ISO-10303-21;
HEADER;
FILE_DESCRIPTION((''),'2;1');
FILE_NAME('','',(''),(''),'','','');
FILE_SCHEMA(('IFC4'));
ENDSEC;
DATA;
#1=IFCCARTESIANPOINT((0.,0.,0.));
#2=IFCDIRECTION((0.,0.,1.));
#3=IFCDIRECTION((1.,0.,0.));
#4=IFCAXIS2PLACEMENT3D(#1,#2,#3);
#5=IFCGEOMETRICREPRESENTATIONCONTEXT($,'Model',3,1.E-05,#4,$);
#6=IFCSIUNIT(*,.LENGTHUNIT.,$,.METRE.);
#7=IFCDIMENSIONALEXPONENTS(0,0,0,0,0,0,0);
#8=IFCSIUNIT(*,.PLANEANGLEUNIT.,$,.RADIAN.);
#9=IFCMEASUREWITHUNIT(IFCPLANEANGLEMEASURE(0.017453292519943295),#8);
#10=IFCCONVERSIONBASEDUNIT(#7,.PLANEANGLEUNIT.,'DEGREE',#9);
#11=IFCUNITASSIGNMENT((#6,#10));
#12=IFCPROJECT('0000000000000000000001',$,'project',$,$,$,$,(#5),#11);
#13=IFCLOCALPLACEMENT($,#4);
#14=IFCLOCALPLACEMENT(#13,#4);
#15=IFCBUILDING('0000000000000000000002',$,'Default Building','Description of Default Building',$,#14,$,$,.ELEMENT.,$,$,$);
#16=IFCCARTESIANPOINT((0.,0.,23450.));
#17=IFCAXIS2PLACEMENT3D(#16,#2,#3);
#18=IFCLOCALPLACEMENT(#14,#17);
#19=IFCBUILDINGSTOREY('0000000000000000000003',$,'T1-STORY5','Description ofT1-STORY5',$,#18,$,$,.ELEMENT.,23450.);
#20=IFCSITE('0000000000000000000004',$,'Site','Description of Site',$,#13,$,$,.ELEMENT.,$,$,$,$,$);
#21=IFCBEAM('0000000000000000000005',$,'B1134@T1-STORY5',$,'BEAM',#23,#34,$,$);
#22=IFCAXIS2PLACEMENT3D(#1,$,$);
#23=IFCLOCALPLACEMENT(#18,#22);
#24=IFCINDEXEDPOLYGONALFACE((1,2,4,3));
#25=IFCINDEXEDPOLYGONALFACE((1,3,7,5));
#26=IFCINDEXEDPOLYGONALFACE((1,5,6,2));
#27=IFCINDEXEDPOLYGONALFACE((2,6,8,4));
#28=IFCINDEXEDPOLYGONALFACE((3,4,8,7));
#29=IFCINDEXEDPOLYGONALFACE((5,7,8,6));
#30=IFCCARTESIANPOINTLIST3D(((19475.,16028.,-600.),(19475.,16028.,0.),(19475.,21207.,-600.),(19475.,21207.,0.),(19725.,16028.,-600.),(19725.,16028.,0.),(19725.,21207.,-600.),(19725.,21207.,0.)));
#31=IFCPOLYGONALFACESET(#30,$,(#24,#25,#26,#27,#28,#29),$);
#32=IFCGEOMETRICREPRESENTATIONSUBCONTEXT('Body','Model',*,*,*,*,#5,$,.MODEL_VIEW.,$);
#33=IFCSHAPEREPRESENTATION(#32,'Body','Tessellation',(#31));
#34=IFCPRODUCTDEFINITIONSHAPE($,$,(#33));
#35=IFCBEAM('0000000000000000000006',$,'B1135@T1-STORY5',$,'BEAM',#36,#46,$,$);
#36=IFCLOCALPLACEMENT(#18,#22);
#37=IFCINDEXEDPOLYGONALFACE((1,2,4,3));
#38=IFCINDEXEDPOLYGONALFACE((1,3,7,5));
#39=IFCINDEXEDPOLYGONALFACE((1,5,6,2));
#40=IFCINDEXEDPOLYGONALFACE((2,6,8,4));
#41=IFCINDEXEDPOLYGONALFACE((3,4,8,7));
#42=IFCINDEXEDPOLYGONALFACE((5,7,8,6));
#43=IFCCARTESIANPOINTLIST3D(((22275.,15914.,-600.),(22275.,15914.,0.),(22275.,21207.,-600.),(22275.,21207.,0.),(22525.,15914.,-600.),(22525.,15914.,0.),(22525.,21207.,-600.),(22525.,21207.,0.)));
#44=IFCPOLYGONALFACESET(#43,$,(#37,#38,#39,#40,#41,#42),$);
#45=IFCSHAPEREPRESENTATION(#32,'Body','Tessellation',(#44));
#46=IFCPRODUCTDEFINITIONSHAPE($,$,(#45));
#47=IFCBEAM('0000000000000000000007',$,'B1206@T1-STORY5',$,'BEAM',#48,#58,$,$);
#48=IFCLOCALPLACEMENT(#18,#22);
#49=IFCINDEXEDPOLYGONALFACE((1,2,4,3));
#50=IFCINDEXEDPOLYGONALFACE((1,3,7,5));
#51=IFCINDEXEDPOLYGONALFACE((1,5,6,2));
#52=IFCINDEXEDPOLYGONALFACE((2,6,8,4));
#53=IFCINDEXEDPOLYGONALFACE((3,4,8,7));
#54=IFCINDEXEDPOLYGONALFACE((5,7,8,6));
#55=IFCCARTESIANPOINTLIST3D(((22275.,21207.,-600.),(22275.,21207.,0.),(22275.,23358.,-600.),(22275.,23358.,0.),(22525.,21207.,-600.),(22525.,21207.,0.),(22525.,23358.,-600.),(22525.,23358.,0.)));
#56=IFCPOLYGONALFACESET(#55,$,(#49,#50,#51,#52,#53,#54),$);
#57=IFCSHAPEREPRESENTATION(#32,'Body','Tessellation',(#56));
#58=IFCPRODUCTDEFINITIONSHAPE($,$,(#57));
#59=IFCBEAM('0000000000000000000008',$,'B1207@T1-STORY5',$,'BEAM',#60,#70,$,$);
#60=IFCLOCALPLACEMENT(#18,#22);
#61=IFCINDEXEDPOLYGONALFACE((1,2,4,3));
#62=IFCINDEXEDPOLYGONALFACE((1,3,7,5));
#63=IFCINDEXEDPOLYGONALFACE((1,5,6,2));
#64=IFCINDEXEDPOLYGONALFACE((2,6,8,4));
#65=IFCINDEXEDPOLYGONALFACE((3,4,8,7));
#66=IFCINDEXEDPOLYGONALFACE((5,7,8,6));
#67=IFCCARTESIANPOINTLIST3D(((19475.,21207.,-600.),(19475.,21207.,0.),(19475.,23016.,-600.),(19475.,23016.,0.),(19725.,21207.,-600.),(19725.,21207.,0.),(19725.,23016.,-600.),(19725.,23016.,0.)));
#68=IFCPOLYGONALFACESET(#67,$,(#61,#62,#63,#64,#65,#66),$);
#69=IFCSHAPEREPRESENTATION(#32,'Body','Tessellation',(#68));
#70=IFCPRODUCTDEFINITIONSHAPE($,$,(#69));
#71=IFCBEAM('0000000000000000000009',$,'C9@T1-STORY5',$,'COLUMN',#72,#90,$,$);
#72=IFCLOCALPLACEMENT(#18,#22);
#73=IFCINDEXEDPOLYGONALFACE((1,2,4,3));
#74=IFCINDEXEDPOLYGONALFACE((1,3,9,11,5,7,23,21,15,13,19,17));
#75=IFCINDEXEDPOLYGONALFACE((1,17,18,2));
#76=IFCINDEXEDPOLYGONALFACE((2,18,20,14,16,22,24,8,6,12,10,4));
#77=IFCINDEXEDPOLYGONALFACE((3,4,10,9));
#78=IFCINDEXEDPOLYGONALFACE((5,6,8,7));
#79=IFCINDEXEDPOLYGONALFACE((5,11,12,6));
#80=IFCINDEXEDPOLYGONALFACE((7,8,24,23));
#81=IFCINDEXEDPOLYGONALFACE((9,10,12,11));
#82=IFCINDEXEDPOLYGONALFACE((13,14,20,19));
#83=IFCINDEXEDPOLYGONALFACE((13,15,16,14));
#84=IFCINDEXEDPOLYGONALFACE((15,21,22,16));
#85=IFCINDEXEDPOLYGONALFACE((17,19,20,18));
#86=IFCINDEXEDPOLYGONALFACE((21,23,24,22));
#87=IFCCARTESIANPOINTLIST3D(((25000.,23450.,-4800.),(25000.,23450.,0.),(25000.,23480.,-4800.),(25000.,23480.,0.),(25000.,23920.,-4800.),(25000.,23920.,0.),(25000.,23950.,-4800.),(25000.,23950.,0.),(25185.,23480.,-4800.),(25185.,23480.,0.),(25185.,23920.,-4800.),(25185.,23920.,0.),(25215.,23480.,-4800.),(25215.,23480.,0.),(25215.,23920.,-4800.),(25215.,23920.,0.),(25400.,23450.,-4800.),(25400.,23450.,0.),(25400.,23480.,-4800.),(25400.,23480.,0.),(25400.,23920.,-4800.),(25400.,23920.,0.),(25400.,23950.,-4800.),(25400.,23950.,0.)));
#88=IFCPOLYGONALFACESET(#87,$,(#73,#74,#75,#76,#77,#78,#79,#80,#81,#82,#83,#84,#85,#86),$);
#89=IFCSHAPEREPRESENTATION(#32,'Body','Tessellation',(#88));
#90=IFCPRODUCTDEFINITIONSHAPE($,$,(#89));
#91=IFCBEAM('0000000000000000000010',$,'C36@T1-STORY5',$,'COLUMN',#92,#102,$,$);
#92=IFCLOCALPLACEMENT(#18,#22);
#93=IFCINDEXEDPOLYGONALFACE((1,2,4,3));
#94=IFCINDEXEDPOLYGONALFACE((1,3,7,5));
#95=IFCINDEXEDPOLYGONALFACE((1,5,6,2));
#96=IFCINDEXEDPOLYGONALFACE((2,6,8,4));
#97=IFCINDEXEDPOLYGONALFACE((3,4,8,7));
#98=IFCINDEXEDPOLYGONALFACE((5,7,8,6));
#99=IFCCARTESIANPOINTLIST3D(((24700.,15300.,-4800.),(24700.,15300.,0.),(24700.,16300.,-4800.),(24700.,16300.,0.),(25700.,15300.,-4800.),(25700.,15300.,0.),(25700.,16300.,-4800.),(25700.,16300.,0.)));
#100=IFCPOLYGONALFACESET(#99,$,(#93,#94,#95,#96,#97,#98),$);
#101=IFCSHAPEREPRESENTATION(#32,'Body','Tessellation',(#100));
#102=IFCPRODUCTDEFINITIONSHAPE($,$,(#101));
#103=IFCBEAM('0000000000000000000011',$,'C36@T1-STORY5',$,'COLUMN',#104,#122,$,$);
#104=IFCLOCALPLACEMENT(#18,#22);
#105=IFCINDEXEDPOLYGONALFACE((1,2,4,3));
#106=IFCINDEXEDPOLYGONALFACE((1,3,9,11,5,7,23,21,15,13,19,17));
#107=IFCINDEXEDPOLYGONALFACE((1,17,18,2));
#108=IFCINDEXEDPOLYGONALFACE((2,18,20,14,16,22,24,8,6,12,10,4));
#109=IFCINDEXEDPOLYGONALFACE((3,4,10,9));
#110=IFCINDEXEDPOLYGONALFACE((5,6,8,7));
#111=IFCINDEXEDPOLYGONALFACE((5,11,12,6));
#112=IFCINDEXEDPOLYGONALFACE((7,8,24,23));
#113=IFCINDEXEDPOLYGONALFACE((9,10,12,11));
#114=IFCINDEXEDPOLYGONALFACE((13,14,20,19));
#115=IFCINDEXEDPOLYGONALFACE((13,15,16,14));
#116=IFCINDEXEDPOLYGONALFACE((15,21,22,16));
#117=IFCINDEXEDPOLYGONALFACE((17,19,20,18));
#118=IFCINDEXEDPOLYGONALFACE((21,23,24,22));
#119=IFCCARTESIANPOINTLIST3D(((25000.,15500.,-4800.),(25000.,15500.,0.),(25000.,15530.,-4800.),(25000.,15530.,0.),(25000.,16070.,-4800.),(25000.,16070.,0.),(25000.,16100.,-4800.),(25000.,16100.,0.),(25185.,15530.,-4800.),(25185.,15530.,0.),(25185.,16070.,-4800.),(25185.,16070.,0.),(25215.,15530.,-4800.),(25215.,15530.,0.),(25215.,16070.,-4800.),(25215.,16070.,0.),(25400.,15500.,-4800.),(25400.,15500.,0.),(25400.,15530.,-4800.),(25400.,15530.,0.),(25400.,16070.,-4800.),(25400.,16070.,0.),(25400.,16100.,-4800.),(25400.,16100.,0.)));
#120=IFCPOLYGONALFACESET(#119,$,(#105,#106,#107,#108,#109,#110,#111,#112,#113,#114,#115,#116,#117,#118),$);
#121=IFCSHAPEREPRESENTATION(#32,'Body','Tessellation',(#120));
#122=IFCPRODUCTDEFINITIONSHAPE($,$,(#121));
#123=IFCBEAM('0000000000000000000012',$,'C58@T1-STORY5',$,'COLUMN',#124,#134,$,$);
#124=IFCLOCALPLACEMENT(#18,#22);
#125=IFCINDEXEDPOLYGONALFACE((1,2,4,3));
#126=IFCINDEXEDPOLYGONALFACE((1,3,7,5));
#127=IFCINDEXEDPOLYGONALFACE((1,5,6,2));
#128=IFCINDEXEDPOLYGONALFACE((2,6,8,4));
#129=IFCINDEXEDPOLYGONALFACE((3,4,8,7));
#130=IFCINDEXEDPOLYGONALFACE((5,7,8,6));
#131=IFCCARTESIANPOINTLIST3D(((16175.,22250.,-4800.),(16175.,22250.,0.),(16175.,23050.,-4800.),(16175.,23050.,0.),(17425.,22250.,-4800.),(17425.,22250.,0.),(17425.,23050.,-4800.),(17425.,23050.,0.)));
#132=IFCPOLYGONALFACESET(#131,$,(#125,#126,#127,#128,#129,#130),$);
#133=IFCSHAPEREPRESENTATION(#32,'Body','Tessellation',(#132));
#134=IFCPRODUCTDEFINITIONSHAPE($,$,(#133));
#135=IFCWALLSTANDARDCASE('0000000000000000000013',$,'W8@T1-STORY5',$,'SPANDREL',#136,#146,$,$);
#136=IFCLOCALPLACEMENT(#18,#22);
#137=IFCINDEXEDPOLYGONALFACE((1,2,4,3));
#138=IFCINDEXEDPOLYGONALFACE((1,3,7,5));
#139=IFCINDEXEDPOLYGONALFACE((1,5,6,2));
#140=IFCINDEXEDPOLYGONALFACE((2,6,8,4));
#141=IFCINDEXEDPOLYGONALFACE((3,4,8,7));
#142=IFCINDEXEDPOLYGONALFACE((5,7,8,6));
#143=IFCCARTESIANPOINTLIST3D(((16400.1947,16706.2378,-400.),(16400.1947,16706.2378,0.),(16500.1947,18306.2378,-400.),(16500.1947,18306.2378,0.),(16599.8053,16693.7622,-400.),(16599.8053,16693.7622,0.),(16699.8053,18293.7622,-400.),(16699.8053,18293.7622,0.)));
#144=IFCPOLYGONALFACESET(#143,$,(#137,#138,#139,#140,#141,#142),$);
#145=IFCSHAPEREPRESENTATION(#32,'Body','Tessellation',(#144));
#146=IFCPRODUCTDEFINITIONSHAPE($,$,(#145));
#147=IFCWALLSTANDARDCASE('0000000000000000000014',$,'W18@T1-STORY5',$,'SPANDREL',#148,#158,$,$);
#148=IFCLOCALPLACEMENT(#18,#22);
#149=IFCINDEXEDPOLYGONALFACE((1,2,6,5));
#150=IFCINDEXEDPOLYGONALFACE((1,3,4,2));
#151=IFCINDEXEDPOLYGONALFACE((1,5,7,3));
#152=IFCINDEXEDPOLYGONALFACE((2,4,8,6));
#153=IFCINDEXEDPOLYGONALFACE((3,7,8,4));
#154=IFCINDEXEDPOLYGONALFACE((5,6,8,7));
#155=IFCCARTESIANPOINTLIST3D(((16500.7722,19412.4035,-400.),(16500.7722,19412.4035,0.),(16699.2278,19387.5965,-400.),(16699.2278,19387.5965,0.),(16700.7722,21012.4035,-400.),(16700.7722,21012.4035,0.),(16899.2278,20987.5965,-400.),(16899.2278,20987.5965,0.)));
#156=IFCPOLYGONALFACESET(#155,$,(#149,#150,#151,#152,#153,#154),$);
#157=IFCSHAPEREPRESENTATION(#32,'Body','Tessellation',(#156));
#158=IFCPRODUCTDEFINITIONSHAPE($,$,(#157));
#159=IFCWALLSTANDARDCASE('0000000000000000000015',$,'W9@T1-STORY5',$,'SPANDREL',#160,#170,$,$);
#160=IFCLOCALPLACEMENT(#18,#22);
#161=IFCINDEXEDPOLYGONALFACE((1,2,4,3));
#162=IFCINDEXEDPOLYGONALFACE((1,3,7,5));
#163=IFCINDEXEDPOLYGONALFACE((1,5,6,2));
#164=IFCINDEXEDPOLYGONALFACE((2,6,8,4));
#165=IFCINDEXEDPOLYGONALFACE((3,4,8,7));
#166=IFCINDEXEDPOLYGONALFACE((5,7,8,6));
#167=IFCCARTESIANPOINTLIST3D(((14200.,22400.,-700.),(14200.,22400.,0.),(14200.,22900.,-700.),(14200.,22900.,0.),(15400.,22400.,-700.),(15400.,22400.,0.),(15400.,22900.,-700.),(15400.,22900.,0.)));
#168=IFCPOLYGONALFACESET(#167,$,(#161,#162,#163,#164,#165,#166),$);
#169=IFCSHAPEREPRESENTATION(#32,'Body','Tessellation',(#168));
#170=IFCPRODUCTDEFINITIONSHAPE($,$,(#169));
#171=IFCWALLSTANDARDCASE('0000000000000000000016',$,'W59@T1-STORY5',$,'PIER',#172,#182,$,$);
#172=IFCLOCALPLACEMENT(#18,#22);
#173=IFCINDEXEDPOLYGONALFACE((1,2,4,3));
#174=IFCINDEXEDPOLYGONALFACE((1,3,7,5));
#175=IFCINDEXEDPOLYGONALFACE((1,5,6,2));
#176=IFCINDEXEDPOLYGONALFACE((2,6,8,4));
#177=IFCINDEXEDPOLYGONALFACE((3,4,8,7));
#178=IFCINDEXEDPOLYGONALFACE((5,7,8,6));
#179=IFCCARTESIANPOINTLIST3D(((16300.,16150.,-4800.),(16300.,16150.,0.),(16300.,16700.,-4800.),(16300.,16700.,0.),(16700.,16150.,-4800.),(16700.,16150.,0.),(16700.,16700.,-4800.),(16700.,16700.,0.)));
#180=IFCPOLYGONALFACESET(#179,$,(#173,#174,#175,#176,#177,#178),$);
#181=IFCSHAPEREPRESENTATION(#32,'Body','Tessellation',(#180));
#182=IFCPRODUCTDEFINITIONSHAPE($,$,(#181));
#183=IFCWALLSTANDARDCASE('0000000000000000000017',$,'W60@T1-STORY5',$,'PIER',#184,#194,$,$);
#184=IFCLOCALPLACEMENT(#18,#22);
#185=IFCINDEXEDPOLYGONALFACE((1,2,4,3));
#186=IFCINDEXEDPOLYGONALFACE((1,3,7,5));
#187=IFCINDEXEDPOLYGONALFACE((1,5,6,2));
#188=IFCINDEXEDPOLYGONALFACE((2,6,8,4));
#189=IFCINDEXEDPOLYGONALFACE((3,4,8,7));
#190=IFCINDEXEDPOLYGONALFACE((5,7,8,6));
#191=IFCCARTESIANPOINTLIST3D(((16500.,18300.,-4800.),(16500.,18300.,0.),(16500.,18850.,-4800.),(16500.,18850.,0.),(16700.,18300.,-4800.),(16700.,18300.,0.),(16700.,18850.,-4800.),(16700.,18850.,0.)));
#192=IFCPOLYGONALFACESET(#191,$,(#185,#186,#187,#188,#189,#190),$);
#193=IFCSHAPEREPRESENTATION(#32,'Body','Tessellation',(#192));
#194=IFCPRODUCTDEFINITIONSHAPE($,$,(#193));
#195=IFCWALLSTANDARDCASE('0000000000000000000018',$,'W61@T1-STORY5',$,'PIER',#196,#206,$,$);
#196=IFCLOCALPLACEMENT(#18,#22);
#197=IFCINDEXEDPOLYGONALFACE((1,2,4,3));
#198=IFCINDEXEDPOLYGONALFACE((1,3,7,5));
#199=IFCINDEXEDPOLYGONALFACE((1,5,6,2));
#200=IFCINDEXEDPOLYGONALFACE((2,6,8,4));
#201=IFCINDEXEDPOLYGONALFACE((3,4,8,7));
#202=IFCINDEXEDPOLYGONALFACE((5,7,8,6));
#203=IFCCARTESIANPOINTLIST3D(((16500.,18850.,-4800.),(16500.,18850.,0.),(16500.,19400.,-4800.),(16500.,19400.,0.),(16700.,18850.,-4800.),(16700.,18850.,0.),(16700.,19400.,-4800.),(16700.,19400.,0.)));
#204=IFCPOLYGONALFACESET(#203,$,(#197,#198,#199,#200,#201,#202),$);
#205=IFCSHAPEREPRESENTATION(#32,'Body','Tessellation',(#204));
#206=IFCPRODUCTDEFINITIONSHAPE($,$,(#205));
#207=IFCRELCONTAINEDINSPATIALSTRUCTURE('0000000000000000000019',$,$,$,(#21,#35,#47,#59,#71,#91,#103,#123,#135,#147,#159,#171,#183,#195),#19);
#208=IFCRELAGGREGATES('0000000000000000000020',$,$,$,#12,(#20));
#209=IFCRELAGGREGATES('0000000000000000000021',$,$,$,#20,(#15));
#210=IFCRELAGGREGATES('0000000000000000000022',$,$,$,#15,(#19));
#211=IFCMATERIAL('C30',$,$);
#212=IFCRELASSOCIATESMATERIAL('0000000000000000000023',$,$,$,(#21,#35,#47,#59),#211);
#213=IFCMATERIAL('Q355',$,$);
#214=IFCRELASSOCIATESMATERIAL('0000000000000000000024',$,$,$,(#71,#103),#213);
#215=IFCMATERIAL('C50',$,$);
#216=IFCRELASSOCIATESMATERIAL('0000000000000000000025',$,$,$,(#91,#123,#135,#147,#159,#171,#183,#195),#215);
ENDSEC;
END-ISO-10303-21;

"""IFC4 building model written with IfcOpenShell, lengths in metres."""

from ifc_helpers import new_model, entity, si_unit, converted_unit, frame, origin_with_axes, place, context, subcontext, project, spatial, indexed_curve, rectangle, i_section, outline, extrude, material, element, save


model = new_model("IFC4")

# Units and contexts
model_context = context("Model", 3, precision=1e-05, world=origin_with_axes())
body_context = subcontext(model_context, "Body", "Model", "MODEL_VIEW")
ifc_project = project(units=[si_unit("LENGTHUNIT", "METRE"), converted_unit("PLANEANGLEUNIT", "DEGREE", entity("IfcPlaneAngleMeasure", 0.017453292519943295), si_unit("PLANEANGLEUNIT", "RADIAN"), dimensions=[0, 0, 0, 0, 0, 0, 0])], contexts=[model_context])

# Site, building, storey
site_placement = place(None, origin_with_axes())
site = spatial("IfcSite", under=ifc_project, at=site_placement, Name="Site", Description="Description of Site", CompositionType="ELEMENT")
building_placement = place(site_placement, origin_with_axes())
building = spatial("IfcBuilding", under=site, at=building_placement, Name="Default Building", Description="Description of Default Building", CompositionType="ELEMENT")
storey_placement = place(building_placement, frame((0.0, 0.0, 23450.0), z_axis=(0.0, 0.0, 1.0), x_axis=(1.0, 0.0, 0.0)))
storey = spatial("IfcBuildingStorey", under=building, at=storey_placement, Name="T1-STORY5", Description="Description ofT1-STORY5", CompositionType="ELEMENT", Elevation=23450.0)

# Beams
ifc_material_1 = material(Name="C30")
beam_1_placement = place(storey_placement, frame((19600.0, 16028.0, -300.0), z_axis=(0.0, 1.0, 0.0), x_axis=(-1.0, 0.0, 0.0)))
element("IfcBeam", 1, at=beam_1_placement, inside=storey, material=ifc_material_1, Name="B1134@T1-STORY5", ObjectType="BEAM", context=body_context, shape_type="SweptSolid", body=[
    extrude(rectangle(XDim=250.0, YDim=600.0), origin_with_axes(), (0.0, 0.0, 1.0), 5179.0),
])
beam_2_placement = place(storey_placement, frame((22400.0, 15914.0, -300.0), z_axis=(0.0, 1.0, 0.0), x_axis=(-1.0, 0.0, 0.0)))
element("IfcBeam", 2, at=beam_2_placement, inside=storey, material=ifc_material_1, Name="B1135@T1-STORY5", ObjectType="BEAM", context=body_context, shape_type="SweptSolid", body=[
    extrude(rectangle(XDim=250.0, YDim=600.0), origin_with_axes(), (0.0, 0.0, 1.0), 5293.0),
])
beam_3_placement = place(storey_placement, frame((22400.0, 21207.0, -300.0), z_axis=(0.0, 1.0, 0.0), x_axis=(-1.0, 0.0, 0.0)))
element("IfcBeam", 3, at=beam_3_placement, inside=storey, material=ifc_material_1, Name="B1206@T1-STORY5", ObjectType="BEAM", context=body_context, shape_type="SweptSolid", body=[
    extrude(rectangle(XDim=250.0, YDim=600.0), origin_with_axes(), (0.0, 0.0, 1.0), 2151.0),
])
beam_4_placement = place(storey_placement, frame((19600.0, 21207.0, -300.0), z_axis=(0.0, 1.0, 0.0), x_axis=(-1.0, 0.0, 0.0)))
element("IfcBeam", 4, at=beam_4_placement, inside=storey, material=ifc_material_1, Name="B1207@T1-STORY5", ObjectType="BEAM", context=body_context, shape_type="SweptSolid", body=[
    extrude(rectangle(XDim=250.0, YDim=600.0), origin_with_axes(), (0.0, 0.0, 1.0), 1809.0),
])
ifc_material_2 = material(Name="C50")
ifc_material_3 = material(Name="Q355")
beam_5_placement = place(storey_placement, frame((25200.0, 23700.0, -4800.0), z_axis=(0.0, 0.0, 1.0), x_axis=(-1.0, 0.0, 0.0)))
element("IfcBeam", 5, at=beam_5_placement, inside=storey, material=ifc_material_3, Name="C9@T1-STORY5", ObjectType="COLUMN", context=body_context, shape_type="SweptSolid", body=[
    extrude(i_section(OverallWidth=400.0, OverallDepth=500.0, WebThickness=30.0, FlangeThickness=30.0, FilletRadius=0.0), origin_with_axes(), (0.0, 0.0, 1.0), 4800.0),
])
beam_6_placement = place(storey_placement, frame((25200.0, 15800.0, -4800.0), z_axis=(0.0, 0.0, 1.0), x_axis=(-1.0, 0.0, 0.0)))
element("IfcBeam", 6, at=beam_6_placement, inside=storey, material=ifc_material_2, Name="C36@T1-STORY5", ObjectType="COLUMN", context=body_context, shape_type="SweptSolid", body=[
    extrude(rectangle(XDim=1000.0, YDim=1000.0), origin_with_axes(), (0.0, 0.0, 1.0), 4800.0),
])
beam_7_placement = place(storey_placement, frame((25200.0, 15800.0, -4800.0), z_axis=(0.0, 0.0, 1.0), x_axis=(-1.0, 0.0, 0.0)))
element("IfcBeam", 7, at=beam_7_placement, inside=storey, material=ifc_material_3, Name="C36@T1-STORY5", ObjectType="COLUMN", context=body_context, shape_type="SweptSolid", body=[
    extrude(i_section(OverallWidth=400.0, OverallDepth=600.0, WebThickness=30.0, FlangeThickness=30.0, FilletRadius=0.0), origin_with_axes(), (0.0, 0.0, 1.0), 4800.0),
])
beam_8_placement = place(storey_placement, frame((16800.0, 22650.0, -4800.0), z_axis=(0.0, 0.0, 1.0), x_axis=(0.0, -1.0, 0.0)))
element("IfcBeam", 8, at=beam_8_placement, inside=storey, material=ifc_material_2, Name="C58@T1-STORY5", ObjectType="COLUMN", context=body_context, shape_type="SweptSolid", body=[
    extrude(rectangle(XDim=800.0, YDim=1250.0), origin_with_axes(), (0.0, 0.0, 1.0), 4800.0),
])

# Walls
wall_1_placement = place(storey_placement, frame((16500.0, 16700.0, -400.0), z_axis=(0.0, 0.0, 1.0), x_axis=(0.062378, 0.998053, 0.0)))
element("IfcWallStandardCase", 9, at=wall_1_placement, inside=storey, material=ifc_material_2, Name="W8@T1-STORY5", ObjectType="SPANDREL", context=body_context, shape_type="SweptSolid", body=[
    extrude(outline(indexed_curve([(0.0, -100.0), (0.0, 100.0), (1603.122, 100.0), (1603.122, -100.0), (0.0, -100.0)], self_intersect=False)), origin_with_axes(), (0.0, 0.0, 1.0), 400.0),
])
wall_2_placement = place(storey_placement, frame((16600.0, 19400.0, -400.0), z_axis=(0.0, 0.0, 1.0), x_axis=(0.124035, 0.992278, 0.0)))
element("IfcWallStandardCase", 10, at=wall_2_placement, inside=storey, material=ifc_material_2, Name="W18@T1-STORY5", ObjectType="SPANDREL", context=body_context, shape_type="SweptSolid", body=[
    extrude(outline(indexed_curve([(0.0, -100.0), (0.0, 100.0), (1612.4515, 100.0), (1612.4515, -100.0), (0.0, -100.0)], self_intersect=False)), origin_with_axes(), (0.0, 0.0, 1.0), 400.0),
])
wall_3_placement = place(storey_placement, frame((14200.0, 22650.0, -700.0), z_axis=(0.0, 0.0, 1.0), x_axis=(1.0, 0.0, 0.0)))
element("IfcWallStandardCase", 11, at=wall_3_placement, inside=storey, material=ifc_material_2, Name="W9@T1-STORY5", ObjectType="SPANDREL", context=body_context, shape_type="SweptSolid", body=[
    extrude(outline(indexed_curve([(0.0, -250.0), (0.0, 250.0), (1200.0, 250.0), (1200.0, -250.0), (0.0, -250.0)], self_intersect=False)), origin_with_axes(), (0.0, 0.0, 1.0), 700.0),
])
wall_4_placement = place(storey_placement, frame((16500.0, 16150.0, -4800.0), z_axis=(0.0, 0.0, 1.0), x_axis=(0.0, 1.0, 0.0)))
element("IfcWallStandardCase", 12, at=wall_4_placement, inside=storey, material=ifc_material_2, Name="W59@T1-STORY5", ObjectType="PIER", context=body_context, shape_type="SweptSolid", body=[
    extrude(outline(indexed_curve([(0.0, -200.0), (0.0, 200.0), (550.0, 200.0), (550.0, -200.0), (0.0, -200.0)], self_intersect=False)), origin_with_axes(), (0.0, 0.0, 1.0), 4800.0),
])
for number, where, z_axis, x_axis, name in (
    (13, (16600.0, 18300.0, -4800.0), (0.0, 0.0, 1.0), (0.0, 1.0, 0.0), "W60@T1-STORY5"),
    (14, (16600.0, 18850.0, -4800.0), (0.0, 0.0, 1.0), (0.0, 1.0, 0.0), "W61@T1-STORY5"),
):
    element("IfcWallStandardCase", number, at=place(storey_placement, frame(where, z_axis=z_axis, x_axis=x_axis)), inside=storey, material=ifc_material_2, Name=name, ObjectType="PIER", context=body_context, shape_type="SweptSolid", body=[
        extrude(outline(indexed_curve([(0.0, -100.0), (0.0, 100.0), (550.0, 100.0), (550.0, -100.0), (0.0, -100.0)], self_intersect=False)), origin_with_axes(), (0.0, 0.0, 1.0), 4800.0),
    ])

save(model, "model.ifc")
